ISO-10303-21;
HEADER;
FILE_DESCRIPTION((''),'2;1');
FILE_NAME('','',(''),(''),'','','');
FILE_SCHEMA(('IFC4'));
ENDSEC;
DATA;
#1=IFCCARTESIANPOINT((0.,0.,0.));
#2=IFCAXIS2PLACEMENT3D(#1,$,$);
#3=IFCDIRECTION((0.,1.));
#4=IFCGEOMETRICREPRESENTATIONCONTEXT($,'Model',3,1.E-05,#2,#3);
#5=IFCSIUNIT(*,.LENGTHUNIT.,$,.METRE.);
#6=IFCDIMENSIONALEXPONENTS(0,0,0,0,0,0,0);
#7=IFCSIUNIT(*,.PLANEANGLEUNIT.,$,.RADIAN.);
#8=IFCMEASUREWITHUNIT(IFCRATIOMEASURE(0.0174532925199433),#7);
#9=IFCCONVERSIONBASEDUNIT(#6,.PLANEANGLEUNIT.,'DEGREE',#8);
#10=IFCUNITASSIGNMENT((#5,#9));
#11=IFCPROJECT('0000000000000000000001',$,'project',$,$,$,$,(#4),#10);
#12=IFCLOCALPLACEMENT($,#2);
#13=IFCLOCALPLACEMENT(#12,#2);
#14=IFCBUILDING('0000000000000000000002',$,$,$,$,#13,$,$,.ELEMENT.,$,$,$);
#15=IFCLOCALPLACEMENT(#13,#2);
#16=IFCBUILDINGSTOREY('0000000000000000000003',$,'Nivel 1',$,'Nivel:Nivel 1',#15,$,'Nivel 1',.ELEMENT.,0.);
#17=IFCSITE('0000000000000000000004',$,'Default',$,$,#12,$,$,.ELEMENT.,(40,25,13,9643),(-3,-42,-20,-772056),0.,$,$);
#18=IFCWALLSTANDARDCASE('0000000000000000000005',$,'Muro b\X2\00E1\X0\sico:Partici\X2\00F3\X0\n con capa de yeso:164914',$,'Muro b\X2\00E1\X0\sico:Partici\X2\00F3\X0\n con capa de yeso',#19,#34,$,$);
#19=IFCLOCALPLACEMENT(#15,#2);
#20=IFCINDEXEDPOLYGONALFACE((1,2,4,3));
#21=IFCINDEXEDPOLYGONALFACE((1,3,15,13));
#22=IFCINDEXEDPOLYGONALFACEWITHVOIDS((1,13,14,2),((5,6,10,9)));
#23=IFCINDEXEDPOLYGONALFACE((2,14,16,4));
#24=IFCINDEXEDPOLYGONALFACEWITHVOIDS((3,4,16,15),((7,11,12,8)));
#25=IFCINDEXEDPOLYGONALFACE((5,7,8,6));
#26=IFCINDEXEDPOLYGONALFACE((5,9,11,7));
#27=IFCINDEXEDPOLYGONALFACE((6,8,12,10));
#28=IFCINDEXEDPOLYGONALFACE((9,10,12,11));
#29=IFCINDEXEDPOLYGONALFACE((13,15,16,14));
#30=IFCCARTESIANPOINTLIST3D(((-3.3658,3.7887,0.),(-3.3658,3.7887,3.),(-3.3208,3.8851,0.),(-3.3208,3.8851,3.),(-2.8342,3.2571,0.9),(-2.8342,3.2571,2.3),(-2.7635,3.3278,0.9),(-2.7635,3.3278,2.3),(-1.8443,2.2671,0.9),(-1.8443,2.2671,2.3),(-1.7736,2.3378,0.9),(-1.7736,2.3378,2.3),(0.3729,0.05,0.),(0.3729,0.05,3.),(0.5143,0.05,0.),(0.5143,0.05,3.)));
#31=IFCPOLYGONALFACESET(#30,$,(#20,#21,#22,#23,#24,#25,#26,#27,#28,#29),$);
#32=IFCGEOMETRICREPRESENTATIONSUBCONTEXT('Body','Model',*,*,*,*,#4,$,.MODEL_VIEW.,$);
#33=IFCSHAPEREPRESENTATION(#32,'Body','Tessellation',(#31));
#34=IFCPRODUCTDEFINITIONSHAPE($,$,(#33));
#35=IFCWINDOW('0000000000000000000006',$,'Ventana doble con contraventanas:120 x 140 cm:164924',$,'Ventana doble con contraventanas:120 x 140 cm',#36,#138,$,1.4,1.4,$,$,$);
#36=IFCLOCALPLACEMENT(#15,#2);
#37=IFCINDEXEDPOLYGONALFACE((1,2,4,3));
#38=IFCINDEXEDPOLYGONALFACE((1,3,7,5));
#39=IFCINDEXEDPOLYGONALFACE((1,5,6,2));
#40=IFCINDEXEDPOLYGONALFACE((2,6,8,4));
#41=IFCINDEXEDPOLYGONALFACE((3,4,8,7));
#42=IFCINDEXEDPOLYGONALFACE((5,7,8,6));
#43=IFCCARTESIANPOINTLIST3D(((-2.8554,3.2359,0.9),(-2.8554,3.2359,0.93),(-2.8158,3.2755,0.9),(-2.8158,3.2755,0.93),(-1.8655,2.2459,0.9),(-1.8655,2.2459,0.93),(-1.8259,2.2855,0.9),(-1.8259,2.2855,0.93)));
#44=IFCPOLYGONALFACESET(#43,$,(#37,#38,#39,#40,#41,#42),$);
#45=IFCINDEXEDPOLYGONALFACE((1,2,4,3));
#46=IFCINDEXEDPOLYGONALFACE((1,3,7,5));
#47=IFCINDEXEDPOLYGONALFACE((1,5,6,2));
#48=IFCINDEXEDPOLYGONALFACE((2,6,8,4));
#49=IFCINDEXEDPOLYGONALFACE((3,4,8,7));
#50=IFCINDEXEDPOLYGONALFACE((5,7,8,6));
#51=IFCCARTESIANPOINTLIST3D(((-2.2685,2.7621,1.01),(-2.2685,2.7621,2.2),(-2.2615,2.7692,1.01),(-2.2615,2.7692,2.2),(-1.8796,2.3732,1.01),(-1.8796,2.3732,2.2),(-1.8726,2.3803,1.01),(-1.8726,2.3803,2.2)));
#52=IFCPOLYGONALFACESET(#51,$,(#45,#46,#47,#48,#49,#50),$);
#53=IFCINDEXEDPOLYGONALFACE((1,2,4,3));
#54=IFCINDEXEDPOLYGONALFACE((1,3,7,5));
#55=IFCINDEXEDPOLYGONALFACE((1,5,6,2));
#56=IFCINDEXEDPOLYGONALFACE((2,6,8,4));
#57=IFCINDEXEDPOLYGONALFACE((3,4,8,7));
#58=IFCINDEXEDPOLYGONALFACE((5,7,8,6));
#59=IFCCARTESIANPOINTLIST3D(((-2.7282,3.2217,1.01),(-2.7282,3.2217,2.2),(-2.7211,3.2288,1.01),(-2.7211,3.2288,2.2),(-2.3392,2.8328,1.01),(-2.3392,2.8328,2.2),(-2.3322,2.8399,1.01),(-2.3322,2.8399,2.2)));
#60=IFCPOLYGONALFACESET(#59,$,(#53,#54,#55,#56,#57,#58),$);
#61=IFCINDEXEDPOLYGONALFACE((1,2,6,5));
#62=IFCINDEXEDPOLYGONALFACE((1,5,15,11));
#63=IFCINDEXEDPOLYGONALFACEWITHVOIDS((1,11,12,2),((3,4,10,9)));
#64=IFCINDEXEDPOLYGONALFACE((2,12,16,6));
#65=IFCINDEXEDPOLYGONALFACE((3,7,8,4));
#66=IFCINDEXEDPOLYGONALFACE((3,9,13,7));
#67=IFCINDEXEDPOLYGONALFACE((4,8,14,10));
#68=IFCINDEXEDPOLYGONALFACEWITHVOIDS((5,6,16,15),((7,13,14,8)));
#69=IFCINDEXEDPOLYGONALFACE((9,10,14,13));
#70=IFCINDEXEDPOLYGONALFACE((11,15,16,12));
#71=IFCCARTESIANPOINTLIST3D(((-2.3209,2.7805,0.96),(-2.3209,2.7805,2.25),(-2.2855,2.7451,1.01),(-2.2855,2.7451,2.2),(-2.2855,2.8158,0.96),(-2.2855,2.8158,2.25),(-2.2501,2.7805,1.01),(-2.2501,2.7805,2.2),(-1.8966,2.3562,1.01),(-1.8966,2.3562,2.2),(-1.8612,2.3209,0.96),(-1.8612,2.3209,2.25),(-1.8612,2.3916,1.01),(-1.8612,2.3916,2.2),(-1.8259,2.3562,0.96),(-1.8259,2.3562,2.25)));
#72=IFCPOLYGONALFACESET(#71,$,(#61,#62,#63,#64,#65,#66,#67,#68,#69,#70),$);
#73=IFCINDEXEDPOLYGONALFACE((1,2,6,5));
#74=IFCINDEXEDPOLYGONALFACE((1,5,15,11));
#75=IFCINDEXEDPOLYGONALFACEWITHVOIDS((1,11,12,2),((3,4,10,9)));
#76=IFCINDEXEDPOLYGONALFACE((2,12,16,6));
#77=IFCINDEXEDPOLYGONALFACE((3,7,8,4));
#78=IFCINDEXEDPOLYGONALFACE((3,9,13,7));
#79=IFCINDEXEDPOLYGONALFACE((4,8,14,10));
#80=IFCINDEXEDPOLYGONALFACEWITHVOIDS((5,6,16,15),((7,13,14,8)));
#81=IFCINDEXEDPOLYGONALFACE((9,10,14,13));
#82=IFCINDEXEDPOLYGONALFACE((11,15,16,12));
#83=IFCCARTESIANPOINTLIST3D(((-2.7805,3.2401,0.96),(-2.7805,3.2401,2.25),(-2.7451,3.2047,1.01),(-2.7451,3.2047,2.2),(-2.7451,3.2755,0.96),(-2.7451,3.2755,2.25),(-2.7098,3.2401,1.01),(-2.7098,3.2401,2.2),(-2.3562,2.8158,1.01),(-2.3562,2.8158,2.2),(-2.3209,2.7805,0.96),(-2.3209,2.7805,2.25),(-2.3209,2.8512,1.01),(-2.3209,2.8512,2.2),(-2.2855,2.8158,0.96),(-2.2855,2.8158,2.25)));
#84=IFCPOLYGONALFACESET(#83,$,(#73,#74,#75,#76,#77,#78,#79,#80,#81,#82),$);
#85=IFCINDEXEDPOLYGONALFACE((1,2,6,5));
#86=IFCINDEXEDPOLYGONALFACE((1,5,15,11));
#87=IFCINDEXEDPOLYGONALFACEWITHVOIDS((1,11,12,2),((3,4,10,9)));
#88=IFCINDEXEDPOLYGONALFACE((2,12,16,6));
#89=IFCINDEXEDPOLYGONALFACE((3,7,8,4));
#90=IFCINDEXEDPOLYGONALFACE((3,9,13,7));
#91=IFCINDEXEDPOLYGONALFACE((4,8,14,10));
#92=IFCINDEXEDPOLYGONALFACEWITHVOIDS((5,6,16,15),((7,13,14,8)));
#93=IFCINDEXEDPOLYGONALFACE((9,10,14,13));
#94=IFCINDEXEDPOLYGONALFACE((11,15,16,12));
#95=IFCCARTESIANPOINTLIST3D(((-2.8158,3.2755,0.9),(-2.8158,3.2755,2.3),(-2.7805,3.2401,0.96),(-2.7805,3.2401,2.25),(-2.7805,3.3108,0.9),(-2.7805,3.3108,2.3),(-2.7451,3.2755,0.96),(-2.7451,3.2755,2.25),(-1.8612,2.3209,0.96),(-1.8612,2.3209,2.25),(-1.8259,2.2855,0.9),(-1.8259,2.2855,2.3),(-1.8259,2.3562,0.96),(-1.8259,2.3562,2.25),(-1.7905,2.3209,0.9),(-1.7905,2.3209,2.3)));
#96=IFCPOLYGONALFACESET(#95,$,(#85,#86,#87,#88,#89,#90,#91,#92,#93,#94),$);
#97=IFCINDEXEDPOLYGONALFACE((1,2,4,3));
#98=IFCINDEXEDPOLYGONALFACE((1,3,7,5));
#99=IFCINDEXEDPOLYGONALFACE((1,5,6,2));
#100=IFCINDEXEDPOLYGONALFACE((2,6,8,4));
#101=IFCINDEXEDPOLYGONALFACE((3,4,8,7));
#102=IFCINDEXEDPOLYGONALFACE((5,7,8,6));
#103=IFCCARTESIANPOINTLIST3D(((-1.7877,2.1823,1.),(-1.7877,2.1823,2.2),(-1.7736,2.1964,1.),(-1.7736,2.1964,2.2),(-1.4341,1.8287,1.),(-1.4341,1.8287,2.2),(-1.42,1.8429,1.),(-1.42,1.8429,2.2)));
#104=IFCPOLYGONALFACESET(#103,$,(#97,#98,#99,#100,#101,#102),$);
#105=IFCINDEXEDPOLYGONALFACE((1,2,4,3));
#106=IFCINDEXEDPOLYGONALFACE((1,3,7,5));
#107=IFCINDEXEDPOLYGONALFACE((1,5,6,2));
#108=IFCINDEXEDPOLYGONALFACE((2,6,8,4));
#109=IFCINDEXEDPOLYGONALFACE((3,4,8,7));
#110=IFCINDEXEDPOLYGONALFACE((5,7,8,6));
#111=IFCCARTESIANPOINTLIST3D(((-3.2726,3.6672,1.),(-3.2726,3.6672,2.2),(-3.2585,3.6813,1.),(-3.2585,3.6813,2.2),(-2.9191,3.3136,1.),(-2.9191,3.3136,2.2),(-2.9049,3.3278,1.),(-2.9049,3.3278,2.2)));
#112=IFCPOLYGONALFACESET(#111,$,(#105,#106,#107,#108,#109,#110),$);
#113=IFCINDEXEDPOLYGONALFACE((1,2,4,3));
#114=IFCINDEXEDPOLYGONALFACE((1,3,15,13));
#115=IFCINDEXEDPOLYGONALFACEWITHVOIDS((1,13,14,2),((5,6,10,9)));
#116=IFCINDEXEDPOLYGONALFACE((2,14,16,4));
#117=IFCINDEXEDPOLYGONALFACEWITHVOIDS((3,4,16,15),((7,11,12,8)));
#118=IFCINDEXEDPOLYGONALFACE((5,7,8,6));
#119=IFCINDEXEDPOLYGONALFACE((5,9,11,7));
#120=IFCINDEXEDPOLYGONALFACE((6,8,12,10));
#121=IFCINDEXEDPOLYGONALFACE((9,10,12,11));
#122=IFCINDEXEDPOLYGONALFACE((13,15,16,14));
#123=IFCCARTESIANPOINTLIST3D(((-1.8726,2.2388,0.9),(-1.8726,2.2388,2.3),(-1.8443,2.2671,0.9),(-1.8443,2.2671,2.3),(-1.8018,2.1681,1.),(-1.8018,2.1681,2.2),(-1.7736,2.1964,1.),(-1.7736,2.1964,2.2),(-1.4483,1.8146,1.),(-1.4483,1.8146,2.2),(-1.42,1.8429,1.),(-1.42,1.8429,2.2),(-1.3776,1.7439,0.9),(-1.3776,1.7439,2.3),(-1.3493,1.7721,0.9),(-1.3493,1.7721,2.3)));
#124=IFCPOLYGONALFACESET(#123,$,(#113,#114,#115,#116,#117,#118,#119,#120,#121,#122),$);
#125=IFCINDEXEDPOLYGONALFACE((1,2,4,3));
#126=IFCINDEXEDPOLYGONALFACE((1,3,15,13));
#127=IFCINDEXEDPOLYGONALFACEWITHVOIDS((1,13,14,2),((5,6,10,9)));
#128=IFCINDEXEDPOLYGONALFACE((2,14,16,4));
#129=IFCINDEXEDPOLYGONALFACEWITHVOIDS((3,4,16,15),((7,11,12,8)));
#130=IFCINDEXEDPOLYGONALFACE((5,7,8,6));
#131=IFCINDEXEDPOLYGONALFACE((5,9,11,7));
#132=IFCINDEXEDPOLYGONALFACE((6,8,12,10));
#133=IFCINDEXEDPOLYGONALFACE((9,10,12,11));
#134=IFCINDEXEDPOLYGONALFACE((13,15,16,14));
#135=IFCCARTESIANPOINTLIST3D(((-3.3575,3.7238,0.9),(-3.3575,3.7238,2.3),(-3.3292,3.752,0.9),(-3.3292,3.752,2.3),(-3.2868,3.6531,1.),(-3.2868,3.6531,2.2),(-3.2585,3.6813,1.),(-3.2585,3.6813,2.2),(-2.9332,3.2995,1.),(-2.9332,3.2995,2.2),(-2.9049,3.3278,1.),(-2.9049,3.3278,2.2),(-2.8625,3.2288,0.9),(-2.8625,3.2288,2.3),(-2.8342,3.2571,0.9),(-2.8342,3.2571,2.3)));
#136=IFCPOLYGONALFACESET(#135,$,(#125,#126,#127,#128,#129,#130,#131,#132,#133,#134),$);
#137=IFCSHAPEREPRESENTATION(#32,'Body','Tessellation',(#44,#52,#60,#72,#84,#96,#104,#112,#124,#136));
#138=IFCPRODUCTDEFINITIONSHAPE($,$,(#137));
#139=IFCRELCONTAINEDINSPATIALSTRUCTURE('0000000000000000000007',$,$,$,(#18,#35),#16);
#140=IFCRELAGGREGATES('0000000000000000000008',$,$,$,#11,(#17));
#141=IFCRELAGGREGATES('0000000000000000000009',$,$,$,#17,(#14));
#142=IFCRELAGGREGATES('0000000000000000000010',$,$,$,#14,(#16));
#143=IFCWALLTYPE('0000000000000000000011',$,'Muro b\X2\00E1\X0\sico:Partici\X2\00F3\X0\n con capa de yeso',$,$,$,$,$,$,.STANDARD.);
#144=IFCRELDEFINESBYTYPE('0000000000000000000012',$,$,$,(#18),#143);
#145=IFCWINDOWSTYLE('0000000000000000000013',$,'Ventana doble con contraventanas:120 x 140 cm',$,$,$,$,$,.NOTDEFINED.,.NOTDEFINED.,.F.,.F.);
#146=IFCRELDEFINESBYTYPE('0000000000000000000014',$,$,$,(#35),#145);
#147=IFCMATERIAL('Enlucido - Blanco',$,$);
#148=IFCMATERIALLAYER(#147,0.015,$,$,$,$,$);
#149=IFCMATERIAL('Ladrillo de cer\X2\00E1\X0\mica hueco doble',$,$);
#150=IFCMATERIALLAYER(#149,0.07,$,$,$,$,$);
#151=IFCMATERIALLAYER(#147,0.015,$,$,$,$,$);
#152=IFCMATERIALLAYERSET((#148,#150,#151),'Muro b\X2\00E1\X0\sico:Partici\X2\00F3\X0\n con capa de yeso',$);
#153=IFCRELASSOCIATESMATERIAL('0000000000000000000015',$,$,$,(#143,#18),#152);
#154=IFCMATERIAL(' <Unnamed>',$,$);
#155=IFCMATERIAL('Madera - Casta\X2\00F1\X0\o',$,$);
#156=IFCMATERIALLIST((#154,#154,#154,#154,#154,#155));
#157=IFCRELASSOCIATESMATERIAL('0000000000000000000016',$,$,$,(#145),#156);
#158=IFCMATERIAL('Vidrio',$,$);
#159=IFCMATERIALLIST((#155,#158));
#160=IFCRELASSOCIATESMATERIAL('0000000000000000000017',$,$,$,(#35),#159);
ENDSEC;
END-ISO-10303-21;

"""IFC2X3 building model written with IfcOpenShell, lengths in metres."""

from ifc_helpers import new_model, entity, si_unit, converted_unit, direction, frame, frame_2d, origin, origin_2d_with_axis, place, context, subcontext, project, spatial, polyline, rectangle, outline, extrude, source, transform, mapped, material, material_list, layer, layer_set, layer_usage, type_object, type_shapes, element, fill, save


model = new_model("IFC2X3")

# Units and contexts
model_context = context("Model", 3, precision=1e-05, world=origin(), true_north=direction((0.0, 1.0)))
body_context = subcontext(model_context, "Body", "Model", "MODEL_VIEW")
ifc_project = project(units=[si_unit("LENGTHUNIT", "METRE"), converted_unit("PLANEANGLEUNIT", "DEGREE", entity("IfcRatioMeasure", 0.0174532925199433), si_unit("PLANEANGLEUNIT", "RADIAN"), dimensions=[0, 0, 0, 0, 0, 0, 0])], contexts=[model_context])

# Site, building, storey
site_placement = place(None, origin())
site = spatial("IfcSite", under=ifc_project, at=site_placement, Name="Default", CompositionType="ELEMENT", RefLatitude=(40, 25, 13, 9643), RefLongitude=(-3, -42, -20, -772056), RefElevation=0.0)
building_placement = place(site_placement, origin())
building = spatial("IfcBuilding", under=site, at=building_placement, CompositionType="ELEMENT")
storey_placement = place(building_placement, origin())
storey = spatial("IfcBuildingStorey", under=building, at=storey_placement, Name="Nivel 1", ObjectType="Nivel:Nivel 1", LongName="Nivel 1", CompositionType="ELEMENT", Elevation=0.0)

# Shared definitions
ifc_material_1 = material(Name="Enlucido - Blanco")
ifc_layer_1 = layer(ifc_material_1, 0.015)
ifc_material_2 = material(Name="Ladrillo de cerámica hueco doble")
ifc_layer_2 = layer(ifc_material_2, 0.07)
ifc_layer_3 = layer(ifc_material_1, 0.015)
ifc_layer_set = layer_set([ifc_layer_1, ifc_layer_2, ifc_layer_3], Name="Muro básico:Partición con capa de yeso")
wall_type = type_object("IfcWallType", Name="Muro básico:Partición con capa de yeso", PredefinedType="STANDARD", material=ifc_layer_set)
ifc_material_3 = material(Name="Madera - Castaño")
ifc_material_4 = material(Name="Vidrio")
ifc_material_5 = material(Name=" <Unnamed>")
ifc_material_list_1 = material_list([ifc_material_5, ifc_material_5, ifc_material_5, ifc_material_5, ifc_material_5, ifc_material_3])
window_style_1 = type_object("IfcWindowStyle", Name="Ventana doble con contraventanas:120 x 140 cm", ConstructionType="NOTDEFINED", OperationType="NOTDEFINED", ParameterTakesPrecedence=False, Sizeable=False, material=ifc_material_list_1)
shared_shape_1 = source(origin(), body_context, "Body", "SweptSolid", [
    extrude(rectangle(XDim=1.4, YDim=0.056, at=frame_2d((0.0, 0.0), x_axis=(1.0, 0.0))), frame((0.7, 0.102, 0.0)), (0.0, 0.0, 1.0), 0.03),
    extrude(rectangle(XDim=0.01, YDim=0.55, at=origin_2d_with_axis()), frame((0.375, 0.045, 0.11), z_axis=(0.0, 0.0, 1.0), x_axis=(0.0, 1.0, 0.0)), (0.0, 0.0, 1.0), 1.19),
    extrude(rectangle(XDim=0.01, YDim=0.55, at=origin_2d_with_axis()), frame((1.025, 0.045, 0.11), z_axis=(0.0, 0.0, 1.0), x_axis=(0.0, 1.0, 0.0)), (0.0, 0.0, 1.0), 1.19),
    extrude(outline(polyline([(-0.645, -0.325), (0.645, -0.325), (0.645, 0.325), (-0.645, 0.325), (-0.645, -0.325)]), holes=[polyline([(-0.595, -0.275), (-0.595, 0.275), (0.595, 0.275), (0.595, -0.275), (-0.595, -0.275)])]), frame((0.375, 0.024, 0.705), z_axis=(0.0, 1.0, 0.0), x_axis=(0.0, 0.0, -1.0)), (0.0, 0.0, 1.0), 0.05),
    extrude(outline(polyline([(-0.325, -0.645), (0.325, -0.645), (0.325, 0.645), (-0.325, 0.645), (-0.325, -0.645)]), holes=[polyline([(-0.275, -0.595), (-0.275, 0.595), (0.275, 0.595), (0.275, -0.595), (-0.275, -0.595)])]), frame((1.025, 0.024, 0.705), z_axis=(0.0, 1.0, 0.0), x_axis=(1.0, 0.0, 0.0)), (0.0, 0.0, 1.0), 0.05),
    extrude(outline(polyline([(-0.7, -0.7), (0.7, -0.7), (0.7, 0.7), (-0.7, 0.7), (-0.7, -0.7)]), holes=[polyline([(-0.65, -0.65), (-0.65, 0.64), (0.65, 0.64), (0.65, -0.65), (-0.65, -0.65)])]), frame((0.7, 0.024, 0.7), z_axis=(0.0, 1.0, 0.0), x_axis=(1.0, 0.0, 0.0)), (0.0, 0.0, 1.0), 0.05),
    extrude(rectangle(XDim=0.02, YDim=0.5, at=origin_2d_with_axis()), frame((-0.35, 0.11, 0.1), z_axis=(0.0, 0.0, 1.0), x_axis=(0.0, 1.0, 0.0)), (0.0, 0.0, 1.0), 1.2),
    extrude(rectangle(XDim=0.02, YDim=0.5, at=frame_2d((0.0, 0.0), x_axis=(1.0, 0.0))), frame((1.75, 0.11, 0.1), z_axis=(0.0, 0.0, 1.0), x_axis=(0.0, 1.0, 0.0)), (0.0, 0.0, 1.0), 1.2),
    extrude(outline(polyline([(-0.35, -0.7), (0.35, -0.7), (0.35, 0.7), (-0.35, 0.7), (-0.35, -0.7)]), holes=[polyline([(-0.25, -0.6), (-0.25, 0.6), (0.25, 0.6), (0.25, -0.6), (-0.25, -0.6)])]), frame((-0.35, 0.1, 0.7), z_axis=(0.0, 1.0, 0.0), x_axis=(1.0, 0.0, 0.0)), (0.0, 0.0, 1.0), 0.04),
    extrude(outline(polyline([(-0.7, -0.35), (0.7, -0.35), (0.7, 0.35), (-0.7, 0.35), (-0.7, -0.35)]), holes=[polyline([(-0.6, 0.25), (0.6, 0.25), (0.6, -0.25), (-0.6, -0.25), (-0.6, 0.25)])]), frame((1.75, 0.1, 0.7), z_axis=(0.0, 1.0, 0.0), x_axis=(0.0, 0.0, -1.0)), (0.0, 0.0, 1.0), 0.04),
])
type_shapes(window_style_1, [shared_shape_1])

# Wall, opening, window
ifc_layer_usage_1 = layer_usage(ifc_layer_set, "AXIS2", "NEGATIVE", 0.05)
wall_1_placement = place(storey_placement, frame((-3.3562, 3.8498, 0.0), z_axis=(0.0, 0.0, 1.0), x_axis=(0.707107, -0.707107, 0.0)))
wall_1 = element("IfcWallStandardCase", 1, at=wall_1_placement, inside=storey, type_object=wall_type, material=ifc_layer_usage_1, Name="Muro básico:Partición con capa de yeso:164914", ObjectType="Muro básico:Partición con capa de yeso", context=body_context, shape_type="SweptSolid", body=[
    extrude(outline(polyline([(5.3237, -0.05), (5.4237, 0.05), (0.0, 0.05), (0.0364, -0.05), (5.3237, -0.05)])), origin(), (0.0, 0.0, 1.0), 3.0),
])
opening_1_placement = place(wall_1_placement, frame((2.1882, 0.05, 0.9)))
opening_1 = element("IfcOpeningElement", 2, at=opening_1_placement, cuts=wall_1, ObjectType="Opening", context=body_context, shape_type="SweptSolid", body=[
    extrude(rectangle(XDim=1.4, YDim=1.4, at=frame_2d((0.7, 0.7), x_axis=(1.0, 0.0))), frame((0.0, 0.0, 0.0), z_axis=(0.0, -1.0, 0.0), x_axis=(0.0, 0.0, 1.0)), (0.0, 0.0, 1.0), 0.1),
])
ifc_material_list_2 = material_list([ifc_material_3, ifc_material_4])
window_1_placement = place(opening_1_placement, frame((0.0, 0.0, 0.0), z_axis=(0.0, 0.0, 1.0), x_axis=(-1.0, 0.0, 0.0)))
window_1 = element("IfcWindow", 3, at=window_1_placement, inside=storey, type_object=window_style_1, material=ifc_material_list_2, Name="Ventana doble con contraventanas:120 x 140 cm:164924", ObjectType="Ventana doble con contraventanas:120 x 140 cm", OverallHeight=1.4, OverallWidth=1.4, context=body_context, shape_type="MappedRepresentation", body=[
    mapped(shared_shape_1, transform((0.0, 0.0, 0.0), scale=1.0)),
])
fill(opening_1, window_1)

save(model, "model.ifc")
